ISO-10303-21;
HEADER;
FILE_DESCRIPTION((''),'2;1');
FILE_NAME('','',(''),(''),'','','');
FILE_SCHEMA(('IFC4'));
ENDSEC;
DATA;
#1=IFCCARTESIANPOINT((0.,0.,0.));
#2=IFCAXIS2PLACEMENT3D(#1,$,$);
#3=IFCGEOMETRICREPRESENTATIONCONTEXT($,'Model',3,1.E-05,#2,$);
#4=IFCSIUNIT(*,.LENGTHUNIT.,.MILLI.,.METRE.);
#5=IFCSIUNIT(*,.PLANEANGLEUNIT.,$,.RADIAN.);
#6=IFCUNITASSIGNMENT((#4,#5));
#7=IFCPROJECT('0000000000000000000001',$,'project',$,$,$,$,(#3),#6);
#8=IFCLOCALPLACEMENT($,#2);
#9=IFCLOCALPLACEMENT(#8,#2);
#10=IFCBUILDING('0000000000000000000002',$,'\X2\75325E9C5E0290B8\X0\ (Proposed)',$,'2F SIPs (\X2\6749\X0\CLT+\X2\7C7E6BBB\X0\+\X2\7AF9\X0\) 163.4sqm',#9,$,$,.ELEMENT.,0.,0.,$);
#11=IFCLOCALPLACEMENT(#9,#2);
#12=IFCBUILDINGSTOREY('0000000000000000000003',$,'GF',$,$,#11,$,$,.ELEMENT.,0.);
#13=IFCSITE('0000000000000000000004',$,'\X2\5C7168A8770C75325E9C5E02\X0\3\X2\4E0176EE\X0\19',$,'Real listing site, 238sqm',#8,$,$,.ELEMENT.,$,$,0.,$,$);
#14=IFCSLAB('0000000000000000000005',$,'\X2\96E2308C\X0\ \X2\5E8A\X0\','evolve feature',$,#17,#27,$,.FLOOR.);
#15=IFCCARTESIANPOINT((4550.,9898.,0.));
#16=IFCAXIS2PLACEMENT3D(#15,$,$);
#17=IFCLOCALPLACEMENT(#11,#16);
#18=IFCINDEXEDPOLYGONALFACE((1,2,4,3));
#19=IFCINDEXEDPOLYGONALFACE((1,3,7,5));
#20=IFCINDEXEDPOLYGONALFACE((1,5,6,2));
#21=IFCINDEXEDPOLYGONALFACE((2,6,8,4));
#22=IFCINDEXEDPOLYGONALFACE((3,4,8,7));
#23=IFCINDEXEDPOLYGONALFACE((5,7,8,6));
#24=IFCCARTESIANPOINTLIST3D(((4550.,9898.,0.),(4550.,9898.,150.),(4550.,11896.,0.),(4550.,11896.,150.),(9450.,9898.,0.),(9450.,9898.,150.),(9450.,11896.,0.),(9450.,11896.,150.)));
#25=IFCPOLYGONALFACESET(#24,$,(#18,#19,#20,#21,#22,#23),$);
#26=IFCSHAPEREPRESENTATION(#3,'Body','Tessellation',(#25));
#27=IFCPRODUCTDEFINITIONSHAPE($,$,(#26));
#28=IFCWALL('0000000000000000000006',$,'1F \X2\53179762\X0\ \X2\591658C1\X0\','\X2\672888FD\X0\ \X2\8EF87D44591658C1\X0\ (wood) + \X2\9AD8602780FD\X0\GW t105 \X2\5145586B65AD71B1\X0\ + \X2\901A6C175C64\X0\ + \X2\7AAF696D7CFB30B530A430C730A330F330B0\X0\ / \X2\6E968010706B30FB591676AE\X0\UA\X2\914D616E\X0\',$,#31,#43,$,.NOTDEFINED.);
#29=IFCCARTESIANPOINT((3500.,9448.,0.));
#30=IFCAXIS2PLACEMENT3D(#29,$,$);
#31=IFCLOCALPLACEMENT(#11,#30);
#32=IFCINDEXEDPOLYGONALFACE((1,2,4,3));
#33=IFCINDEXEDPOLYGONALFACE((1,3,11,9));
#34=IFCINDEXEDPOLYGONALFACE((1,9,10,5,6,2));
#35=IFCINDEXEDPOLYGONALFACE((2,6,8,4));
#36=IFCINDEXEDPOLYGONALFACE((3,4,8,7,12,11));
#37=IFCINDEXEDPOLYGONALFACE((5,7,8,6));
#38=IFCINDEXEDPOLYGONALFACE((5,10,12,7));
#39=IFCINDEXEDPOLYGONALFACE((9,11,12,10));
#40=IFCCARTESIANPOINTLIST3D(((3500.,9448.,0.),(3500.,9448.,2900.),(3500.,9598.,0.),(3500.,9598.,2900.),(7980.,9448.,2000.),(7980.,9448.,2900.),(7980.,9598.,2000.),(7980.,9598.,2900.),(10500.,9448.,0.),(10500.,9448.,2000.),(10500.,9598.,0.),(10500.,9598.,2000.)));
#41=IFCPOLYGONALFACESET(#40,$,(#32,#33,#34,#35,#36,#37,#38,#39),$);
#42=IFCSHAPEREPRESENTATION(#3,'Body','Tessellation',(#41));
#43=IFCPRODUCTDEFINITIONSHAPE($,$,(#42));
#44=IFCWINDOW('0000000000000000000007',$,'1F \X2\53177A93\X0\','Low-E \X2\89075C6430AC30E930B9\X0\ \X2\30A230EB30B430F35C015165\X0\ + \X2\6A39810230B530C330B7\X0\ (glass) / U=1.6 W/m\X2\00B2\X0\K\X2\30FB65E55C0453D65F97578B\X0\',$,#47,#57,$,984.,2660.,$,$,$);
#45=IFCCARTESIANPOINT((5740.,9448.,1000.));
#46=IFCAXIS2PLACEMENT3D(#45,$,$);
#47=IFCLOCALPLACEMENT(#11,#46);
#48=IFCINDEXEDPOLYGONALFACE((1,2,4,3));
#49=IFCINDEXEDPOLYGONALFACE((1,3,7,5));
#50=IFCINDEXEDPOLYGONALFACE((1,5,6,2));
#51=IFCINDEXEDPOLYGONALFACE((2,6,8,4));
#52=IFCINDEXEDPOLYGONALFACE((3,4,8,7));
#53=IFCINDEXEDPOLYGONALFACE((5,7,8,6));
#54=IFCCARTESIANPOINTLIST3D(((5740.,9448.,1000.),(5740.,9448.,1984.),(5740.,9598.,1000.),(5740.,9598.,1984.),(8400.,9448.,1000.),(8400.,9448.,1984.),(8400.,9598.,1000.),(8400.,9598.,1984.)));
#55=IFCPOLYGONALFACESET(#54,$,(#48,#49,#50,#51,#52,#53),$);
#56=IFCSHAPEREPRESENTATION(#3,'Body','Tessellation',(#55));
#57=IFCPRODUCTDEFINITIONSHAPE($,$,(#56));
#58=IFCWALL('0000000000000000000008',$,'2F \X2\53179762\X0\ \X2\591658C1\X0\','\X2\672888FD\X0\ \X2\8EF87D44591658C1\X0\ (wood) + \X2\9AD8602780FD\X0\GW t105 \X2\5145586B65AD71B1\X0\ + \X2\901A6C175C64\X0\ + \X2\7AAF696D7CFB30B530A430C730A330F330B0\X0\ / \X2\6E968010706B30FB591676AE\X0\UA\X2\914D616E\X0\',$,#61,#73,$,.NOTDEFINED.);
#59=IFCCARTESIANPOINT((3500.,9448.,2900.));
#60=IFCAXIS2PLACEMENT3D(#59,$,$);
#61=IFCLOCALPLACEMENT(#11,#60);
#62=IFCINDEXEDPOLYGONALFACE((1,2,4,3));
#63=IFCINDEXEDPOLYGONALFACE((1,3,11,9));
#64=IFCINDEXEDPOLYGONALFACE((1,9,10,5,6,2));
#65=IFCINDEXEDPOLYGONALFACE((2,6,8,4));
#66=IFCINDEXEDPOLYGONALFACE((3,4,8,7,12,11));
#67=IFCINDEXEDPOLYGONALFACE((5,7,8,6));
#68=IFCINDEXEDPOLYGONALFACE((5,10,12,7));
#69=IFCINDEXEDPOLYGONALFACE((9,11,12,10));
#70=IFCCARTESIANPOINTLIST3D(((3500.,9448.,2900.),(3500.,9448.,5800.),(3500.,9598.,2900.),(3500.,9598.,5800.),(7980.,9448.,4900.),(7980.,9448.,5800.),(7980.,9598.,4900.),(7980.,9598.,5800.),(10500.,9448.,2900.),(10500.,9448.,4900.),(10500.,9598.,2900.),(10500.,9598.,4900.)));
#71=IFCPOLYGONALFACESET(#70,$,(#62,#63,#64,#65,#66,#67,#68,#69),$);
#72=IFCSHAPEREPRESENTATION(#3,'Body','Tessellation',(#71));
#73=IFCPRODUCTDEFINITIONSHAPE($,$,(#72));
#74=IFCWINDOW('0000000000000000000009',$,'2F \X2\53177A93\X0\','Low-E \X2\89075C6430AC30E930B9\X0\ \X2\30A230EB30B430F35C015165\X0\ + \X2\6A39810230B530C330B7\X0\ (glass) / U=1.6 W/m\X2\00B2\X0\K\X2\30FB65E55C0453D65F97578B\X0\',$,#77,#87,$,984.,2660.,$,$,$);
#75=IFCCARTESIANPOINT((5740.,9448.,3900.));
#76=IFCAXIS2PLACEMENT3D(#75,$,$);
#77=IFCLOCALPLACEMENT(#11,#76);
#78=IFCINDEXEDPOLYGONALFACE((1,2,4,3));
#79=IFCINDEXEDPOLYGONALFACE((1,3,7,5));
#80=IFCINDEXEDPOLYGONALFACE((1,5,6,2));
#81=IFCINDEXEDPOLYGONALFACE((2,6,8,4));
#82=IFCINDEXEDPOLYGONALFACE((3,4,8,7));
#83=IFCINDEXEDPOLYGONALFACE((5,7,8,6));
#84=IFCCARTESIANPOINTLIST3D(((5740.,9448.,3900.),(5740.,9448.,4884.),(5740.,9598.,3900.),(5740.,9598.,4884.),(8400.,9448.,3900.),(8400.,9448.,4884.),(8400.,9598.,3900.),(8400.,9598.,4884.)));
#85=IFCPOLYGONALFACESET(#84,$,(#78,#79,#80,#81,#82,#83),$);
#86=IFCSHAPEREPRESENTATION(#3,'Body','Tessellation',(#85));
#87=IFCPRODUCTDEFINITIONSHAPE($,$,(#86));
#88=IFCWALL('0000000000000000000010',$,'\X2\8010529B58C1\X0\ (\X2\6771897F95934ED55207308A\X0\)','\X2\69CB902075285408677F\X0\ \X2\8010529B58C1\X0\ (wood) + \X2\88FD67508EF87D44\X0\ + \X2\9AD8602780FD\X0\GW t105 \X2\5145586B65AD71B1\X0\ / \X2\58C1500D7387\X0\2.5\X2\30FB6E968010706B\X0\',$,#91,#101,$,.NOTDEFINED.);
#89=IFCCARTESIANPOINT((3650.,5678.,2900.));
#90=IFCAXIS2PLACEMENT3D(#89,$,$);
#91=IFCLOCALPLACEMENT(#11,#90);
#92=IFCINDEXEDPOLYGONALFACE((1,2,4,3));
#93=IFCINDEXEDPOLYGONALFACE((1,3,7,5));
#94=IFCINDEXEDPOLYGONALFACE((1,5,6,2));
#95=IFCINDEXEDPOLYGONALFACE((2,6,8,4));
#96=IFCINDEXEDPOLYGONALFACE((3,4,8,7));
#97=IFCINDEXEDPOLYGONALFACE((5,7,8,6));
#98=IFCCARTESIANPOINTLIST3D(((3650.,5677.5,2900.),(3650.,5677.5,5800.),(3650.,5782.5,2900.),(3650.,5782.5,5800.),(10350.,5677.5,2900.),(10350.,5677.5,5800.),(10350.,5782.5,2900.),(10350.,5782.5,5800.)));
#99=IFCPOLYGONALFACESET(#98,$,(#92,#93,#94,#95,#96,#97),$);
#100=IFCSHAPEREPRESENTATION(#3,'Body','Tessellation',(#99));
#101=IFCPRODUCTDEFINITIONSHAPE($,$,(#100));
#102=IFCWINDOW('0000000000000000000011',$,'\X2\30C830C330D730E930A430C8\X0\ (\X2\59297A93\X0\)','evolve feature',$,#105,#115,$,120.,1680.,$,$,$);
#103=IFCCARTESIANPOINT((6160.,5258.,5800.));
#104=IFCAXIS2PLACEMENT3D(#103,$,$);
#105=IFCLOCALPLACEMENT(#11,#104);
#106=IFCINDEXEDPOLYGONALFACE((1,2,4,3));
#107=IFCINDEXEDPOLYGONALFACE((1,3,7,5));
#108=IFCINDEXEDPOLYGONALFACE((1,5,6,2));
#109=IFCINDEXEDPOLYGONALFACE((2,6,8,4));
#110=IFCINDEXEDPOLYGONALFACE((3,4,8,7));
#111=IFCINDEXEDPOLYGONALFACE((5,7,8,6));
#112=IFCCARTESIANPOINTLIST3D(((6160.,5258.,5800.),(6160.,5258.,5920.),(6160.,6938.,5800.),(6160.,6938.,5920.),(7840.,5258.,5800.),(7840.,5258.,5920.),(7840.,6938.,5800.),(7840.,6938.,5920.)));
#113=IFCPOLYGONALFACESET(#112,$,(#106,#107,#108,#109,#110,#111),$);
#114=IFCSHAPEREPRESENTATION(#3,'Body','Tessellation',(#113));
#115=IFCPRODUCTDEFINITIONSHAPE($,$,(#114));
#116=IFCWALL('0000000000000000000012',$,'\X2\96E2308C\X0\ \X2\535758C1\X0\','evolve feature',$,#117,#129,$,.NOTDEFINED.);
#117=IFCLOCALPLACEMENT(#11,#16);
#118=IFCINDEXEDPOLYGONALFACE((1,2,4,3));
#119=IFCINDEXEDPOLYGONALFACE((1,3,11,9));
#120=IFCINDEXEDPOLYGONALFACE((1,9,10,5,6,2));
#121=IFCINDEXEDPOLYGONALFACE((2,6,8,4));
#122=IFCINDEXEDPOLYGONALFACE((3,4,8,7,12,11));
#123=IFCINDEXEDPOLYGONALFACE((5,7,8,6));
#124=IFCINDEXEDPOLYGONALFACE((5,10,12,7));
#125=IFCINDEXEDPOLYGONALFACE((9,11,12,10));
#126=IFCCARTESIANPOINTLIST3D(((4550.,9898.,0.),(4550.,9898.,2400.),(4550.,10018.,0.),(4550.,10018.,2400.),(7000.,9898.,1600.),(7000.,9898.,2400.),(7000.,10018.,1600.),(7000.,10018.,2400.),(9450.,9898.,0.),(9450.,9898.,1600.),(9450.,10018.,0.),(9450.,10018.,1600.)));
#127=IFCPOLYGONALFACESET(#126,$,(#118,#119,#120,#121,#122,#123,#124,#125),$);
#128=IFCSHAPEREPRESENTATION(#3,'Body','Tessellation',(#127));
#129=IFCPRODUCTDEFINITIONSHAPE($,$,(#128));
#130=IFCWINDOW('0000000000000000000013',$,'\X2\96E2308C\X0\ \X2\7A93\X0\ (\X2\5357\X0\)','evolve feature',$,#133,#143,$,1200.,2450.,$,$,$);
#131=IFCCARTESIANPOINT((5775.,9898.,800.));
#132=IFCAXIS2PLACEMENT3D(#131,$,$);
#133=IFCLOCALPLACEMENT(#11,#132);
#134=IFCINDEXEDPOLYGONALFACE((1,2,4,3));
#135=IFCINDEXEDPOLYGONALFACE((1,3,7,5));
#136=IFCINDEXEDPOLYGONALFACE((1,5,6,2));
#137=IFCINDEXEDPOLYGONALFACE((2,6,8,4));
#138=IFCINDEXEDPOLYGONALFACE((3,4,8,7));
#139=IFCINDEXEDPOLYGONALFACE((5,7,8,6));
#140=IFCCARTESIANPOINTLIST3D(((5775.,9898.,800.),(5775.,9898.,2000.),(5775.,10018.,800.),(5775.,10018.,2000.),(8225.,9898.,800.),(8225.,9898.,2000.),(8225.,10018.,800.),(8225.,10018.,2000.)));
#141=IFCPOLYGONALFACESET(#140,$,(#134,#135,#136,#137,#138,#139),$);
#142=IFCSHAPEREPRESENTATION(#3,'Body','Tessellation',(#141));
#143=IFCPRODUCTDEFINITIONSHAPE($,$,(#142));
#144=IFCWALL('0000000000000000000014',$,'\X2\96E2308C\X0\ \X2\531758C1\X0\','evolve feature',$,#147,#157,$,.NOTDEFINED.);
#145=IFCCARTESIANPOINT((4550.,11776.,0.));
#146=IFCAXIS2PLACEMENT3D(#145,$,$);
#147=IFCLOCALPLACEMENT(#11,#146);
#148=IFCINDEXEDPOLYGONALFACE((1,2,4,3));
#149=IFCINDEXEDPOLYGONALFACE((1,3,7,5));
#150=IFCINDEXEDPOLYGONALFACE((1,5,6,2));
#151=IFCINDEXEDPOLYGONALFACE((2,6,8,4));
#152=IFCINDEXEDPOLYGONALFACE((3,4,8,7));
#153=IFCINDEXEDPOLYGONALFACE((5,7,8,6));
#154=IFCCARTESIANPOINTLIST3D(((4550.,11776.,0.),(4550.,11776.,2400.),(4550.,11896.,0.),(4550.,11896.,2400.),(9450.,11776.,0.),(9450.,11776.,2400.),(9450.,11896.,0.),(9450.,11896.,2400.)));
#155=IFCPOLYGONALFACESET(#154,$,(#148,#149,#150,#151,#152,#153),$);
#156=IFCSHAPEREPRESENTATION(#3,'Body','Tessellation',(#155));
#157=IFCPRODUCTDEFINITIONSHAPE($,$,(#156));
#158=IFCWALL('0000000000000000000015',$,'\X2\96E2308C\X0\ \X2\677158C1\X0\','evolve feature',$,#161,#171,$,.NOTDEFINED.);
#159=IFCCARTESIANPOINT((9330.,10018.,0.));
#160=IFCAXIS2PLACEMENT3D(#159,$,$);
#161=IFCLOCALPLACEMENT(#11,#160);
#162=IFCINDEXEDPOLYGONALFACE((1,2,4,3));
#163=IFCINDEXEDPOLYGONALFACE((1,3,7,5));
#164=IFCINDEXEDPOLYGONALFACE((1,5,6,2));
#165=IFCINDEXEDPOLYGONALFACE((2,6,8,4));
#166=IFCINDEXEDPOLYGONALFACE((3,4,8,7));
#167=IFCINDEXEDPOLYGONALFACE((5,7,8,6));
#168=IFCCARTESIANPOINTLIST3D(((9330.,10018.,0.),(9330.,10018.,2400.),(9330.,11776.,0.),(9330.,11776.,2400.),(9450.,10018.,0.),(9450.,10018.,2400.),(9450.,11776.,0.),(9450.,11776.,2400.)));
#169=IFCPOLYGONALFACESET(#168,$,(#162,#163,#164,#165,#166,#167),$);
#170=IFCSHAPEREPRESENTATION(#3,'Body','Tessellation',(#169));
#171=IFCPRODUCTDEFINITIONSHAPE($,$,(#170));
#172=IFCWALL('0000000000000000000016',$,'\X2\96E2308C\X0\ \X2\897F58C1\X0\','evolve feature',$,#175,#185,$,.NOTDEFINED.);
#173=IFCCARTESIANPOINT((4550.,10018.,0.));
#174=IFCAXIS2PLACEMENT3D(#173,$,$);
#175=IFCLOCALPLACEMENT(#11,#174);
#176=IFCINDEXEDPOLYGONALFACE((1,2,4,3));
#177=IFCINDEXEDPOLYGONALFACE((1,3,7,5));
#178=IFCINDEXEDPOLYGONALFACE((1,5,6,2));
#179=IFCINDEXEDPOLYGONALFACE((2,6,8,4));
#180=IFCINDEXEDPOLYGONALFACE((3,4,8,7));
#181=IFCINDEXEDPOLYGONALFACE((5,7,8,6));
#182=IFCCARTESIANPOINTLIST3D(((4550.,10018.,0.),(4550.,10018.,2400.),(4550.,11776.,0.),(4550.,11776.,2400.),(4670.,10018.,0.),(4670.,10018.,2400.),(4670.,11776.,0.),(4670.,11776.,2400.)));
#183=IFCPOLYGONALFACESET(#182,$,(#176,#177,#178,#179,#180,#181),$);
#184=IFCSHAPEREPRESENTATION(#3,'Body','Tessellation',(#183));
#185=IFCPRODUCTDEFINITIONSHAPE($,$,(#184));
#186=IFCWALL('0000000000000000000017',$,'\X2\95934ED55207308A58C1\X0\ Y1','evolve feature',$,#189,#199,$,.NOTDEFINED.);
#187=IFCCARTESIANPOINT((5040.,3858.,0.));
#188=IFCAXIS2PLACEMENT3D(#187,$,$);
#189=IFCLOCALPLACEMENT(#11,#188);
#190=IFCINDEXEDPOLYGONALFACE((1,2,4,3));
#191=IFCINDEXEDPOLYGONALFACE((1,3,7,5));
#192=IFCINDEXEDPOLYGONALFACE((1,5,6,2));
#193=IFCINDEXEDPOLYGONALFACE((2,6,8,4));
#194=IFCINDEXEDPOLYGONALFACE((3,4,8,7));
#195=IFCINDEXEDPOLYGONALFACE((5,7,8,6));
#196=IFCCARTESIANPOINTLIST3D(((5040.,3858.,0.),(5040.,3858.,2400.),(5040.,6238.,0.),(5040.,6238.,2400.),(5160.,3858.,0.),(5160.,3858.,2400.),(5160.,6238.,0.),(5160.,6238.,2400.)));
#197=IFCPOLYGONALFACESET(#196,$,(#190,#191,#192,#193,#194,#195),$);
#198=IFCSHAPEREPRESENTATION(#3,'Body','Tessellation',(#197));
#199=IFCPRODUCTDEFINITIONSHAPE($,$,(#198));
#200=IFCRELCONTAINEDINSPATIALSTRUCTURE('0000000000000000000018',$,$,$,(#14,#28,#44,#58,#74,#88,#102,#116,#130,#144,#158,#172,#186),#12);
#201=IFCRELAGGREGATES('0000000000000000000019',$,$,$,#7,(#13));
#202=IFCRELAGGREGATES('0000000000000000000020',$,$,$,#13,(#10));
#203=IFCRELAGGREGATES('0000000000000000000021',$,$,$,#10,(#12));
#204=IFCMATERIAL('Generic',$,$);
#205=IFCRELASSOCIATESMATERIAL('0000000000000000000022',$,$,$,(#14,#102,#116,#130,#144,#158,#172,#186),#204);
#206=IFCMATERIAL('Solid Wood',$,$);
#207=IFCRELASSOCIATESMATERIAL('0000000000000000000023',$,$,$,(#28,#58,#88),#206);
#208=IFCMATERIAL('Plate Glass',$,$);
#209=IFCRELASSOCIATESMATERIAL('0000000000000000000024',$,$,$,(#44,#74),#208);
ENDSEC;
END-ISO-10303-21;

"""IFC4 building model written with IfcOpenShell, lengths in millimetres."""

from ifc_helpers import new_model, si_unit, frame, frame_2d, origin, place, context, project, spatial, rectangle, extrude, material, element, fill, save


model = new_model("IFC4")

# Units and contexts
model_context = context("Model", 3, precision=1e-05, world=origin())
ifc_project = project(units=[si_unit("LENGTHUNIT", "METRE", prefix="MILLI"), si_unit("PLANEANGLEUNIT", "RADIAN")], contexts=[model_context])

# Site, building, storey
site_placement = place(None, origin())
site = spatial("IfcSite", under=ifc_project, at=site_placement, Name="山梨県甲府市3丁目19", ObjectType="Real listing site, 238sqm", CompositionType="ELEMENT", RefElevation=0.0)
building_placement = place(site_placement, origin())
building = spatial("IfcBuilding", under=site, at=building_placement, Name="甲府市邸 (Proposed)", ObjectType="2F SIPs (杉CLT+籾殻+竹) 163.4sqm", CompositionType="ELEMENT", ElevationOfRefHeight=0.0, ElevationOfTerrain=0.0)
storey_placement = place(building_placement, origin())
storey = spatial("IfcBuildingStorey", under=building, at=storey_placement, Name="GF", CompositionType="ELEMENT", Elevation=0.0)

# Slab
ifc_material_1 = material(Name="Generic")
slab_placement = place(storey_placement, frame((4550.0, 9898.0, 0.0)))
element("IfcSlab", 1, at=slab_placement, inside=storey, material=ifc_material_1, Name="離れ 床", Description="evolve feature", PredefinedType="FLOOR", context=model_context, shape_type="SweptSolid", body=[
    extrude(rectangle(XDim=4900.0, YDim=1998.0, at=frame_2d((2450.0, 999.0))), frame((4550.0, 9898.0, 0.0)), (0.0, 0.0, 1.0), 150.0),
])

# Wall, opening, window
ifc_material_2 = material(Name="Solid Wood")
wall_1_placement = place(storey_placement, frame((3500.0, 9448.0, 0.0)))
wall_1 = element("IfcWall", 2, at=wall_1_placement, inside=storey, material=ifc_material_2, Name="1F 北面 外壁", Description="木製 軸組外壁 (wood) + 高性能GW t105 充填断熱 + 通気層 + 窯業系サイディング / 準耐火・外皮UA配慮", PredefinedType="NOTDEFINED", context=model_context, shape_type="SweptSolid", body=[
    extrude(rectangle(XDim=7000.0, YDim=150.0, at=frame_2d((3500.0, 75.0))), frame((3500.0, 9448.0, 0.0)), (0.0, 0.0, 1.0), 2900.0),
])
opening_1_placement = place(storey_placement, frame((5740.0, 9448.0, 1000.0)))
opening_1 = element("IfcOpeningElement", 3, at=opening_1_placement, cuts=wall_1, PredefinedType="NOTDEFINED", context=model_context, shape_type="SweptSolid", body=[
    extrude(rectangle(XDim=2660.0, YDim=150.0, at=frame_2d((1330.0, 75.0))), frame((5740.0, 9448.0, 1000.0)), (0.0, 0.0, 1.0), 984.0),
])
ifc_material_3 = material(Name="Plate Glass")
window_1_placement = place(storey_placement, frame((5740.0, 9448.0, 1000.0)))
window_1 = element("IfcWindow", 4, at=window_1_placement, inside=storey, material=ifc_material_3, Name="1F 北窓", Description="Low-E 複層ガラス アルゴン封入 + 樹脂サッシ (glass) / U=1.6 W/m²K・日射取得型", OverallHeight=984.0, OverallWidth=2660.0, context=model_context, shape_type="SweptSolid", body=[
    extrude(rectangle(XDim=2660.0, YDim=150.0, at=frame_2d((1330.0, 75.0))), frame((5740.0, 9448.0, 1000.0)), (0.0, 0.0, 1.0), 984.0),
])
fill(opening_1, window_1)

# Wall, opening, window
wall_2_placement = place(storey_placement, frame((3500.0, 9448.0, 2900.0)))
wall_2 = element("IfcWall", 5, at=wall_2_placement, inside=storey, material=ifc_material_2, Name="2F 北面 外壁", Description="木製 軸組外壁 (wood) + 高性能GW t105 充填断熱 + 通気層 + 窯業系サイディング / 準耐火・外皮UA配慮", PredefinedType="NOTDEFINED", context=model_context, shape_type="SweptSolid", body=[
    extrude(rectangle(XDim=7000.0, YDim=150.0, at=frame_2d((3500.0, 75.0))), frame((3500.0, 9448.0, 2900.0)), (0.0, 0.0, 1.0), 2900.0),
])
opening_2_placement = place(storey_placement, frame((5740.0, 9448.0, 3900.0)))
opening_2 = element("IfcOpeningElement", 6, at=opening_2_placement, cuts=wall_2, PredefinedType="NOTDEFINED", context=model_context, shape_type="SweptSolid", body=[
    extrude(rectangle(XDim=2660.0, YDim=150.0, at=frame_2d((1330.0, 75.0))), frame((5740.0, 9448.0, 3900.0)), (0.0, 0.0, 1.0), 984.0),
])
window_2_placement = place(storey_placement, frame((5740.0, 9448.0, 3900.0)))
window_2 = element("IfcWindow", 7, at=window_2_placement, inside=storey, material=ifc_material_3, Name="2F 北窓", Description="Low-E 複層ガラス アルゴン封入 + 樹脂サッシ (glass) / U=1.6 W/m²K・日射取得型", OverallHeight=984.0, OverallWidth=2660.0, context=model_context, shape_type="SweptSolid", body=[
    extrude(rectangle(XDim=2660.0, YDim=150.0, at=frame_2d((1330.0, 75.0))), frame((5740.0, 9448.0, 3900.0)), (0.0, 0.0, 1.0), 984.0),
])
fill(opening_2, window_2)

# Wall
wall_3_placement = place(storey_placement, frame((3650.0, 5678.0, 2900.0)))
element("IfcWall", 8, at=wall_3_placement, inside=storey, material=ifc_material_2, Name="耐力壁 (東西間仕切り)", Description="構造用合板 耐力壁 (wood) + 製材軸組 + 高性能GW t105 充填断熱 / 壁倍率2.5・準耐火", PredefinedType="NOTDEFINED", context=model_context, shape_type="SweptSolid", body=[
    extrude(rectangle(XDim=6700.0, YDim=105.0, at=frame_2d((3350.0, 52.0))), frame((3650.0, 5678.0, 2900.0)), (0.0, 0.0, 1.0), 2900.0),
])

# Window
window_3_placement = place(storey_placement, frame((6160.0, 5258.0, 5800.0)))
element("IfcWindow", 9, at=window_3_placement, inside=storey, material=ifc_material_1, Name="トップライト (天窓)", Description="evolve feature", OverallHeight=120.0, OverallWidth=1680.0, context=model_context, shape_type="SweptSolid", body=[
    extrude(rectangle(XDim=1680.0, YDim=1680.0, at=frame_2d((840.0, 840.0))), frame((6160.0, 5258.0, 5800.0)), (0.0, 0.0, 1.0), 120.0),
])

# Wall, opening, window
wall_4_placement = place(storey_placement, frame((4550.0, 9898.0, 0.0)))
wall_4 = element("IfcWall", 10, at=wall_4_placement, inside=storey, material=ifc_material_1, Name="離れ 南壁", Description="evolve feature", PredefinedType="NOTDEFINED", context=model_context, shape_type="SweptSolid", body=[
    extrude(rectangle(XDim=4900.0, YDim=120.0, at=frame_2d((2450.0, 60.0))), frame((4550.0, 9898.0, 0.0)), (0.0, 0.0, 1.0), 2400.0),
])
opening_3_placement = place(storey_placement, frame((5775.0, 9898.0, 800.0)))
opening_3 = element("IfcOpeningElement", 11, at=opening_3_placement, cuts=wall_4, PredefinedType="NOTDEFINED", context=model_context, shape_type="SweptSolid", body=[
    extrude(rectangle(XDim=2450.0, YDim=120.0, at=frame_2d((1225.0, 60.0))), frame((5775.0, 9898.0, 800.0)), (0.0, 0.0, 1.0), 1200.0),
])
window_4_placement = place(storey_placement, frame((5775.0, 9898.0, 800.0)))
window_4 = element("IfcWindow", 12, at=window_4_placement, inside=storey, material=ifc_material_1, Name="離れ 窓 (南)", Description="evolve feature", OverallHeight=1200.0, OverallWidth=2450.0, context=model_context, shape_type="SweptSolid", body=[
    extrude(rectangle(XDim=2450.0, YDim=120.0, at=frame_2d((1225.0, 60.0))), frame((5775.0, 9898.0, 800.0)), (0.0, 0.0, 1.0), 1200.0),
])
fill(opening_3, window_4)

# Walls
wall_5_placement = place(storey_placement, frame((4550.0, 11776.0, 0.0)))
element("IfcWall", 13, at=wall_5_placement, inside=storey, material=ifc_material_1, Name="離れ 北壁", Description="evolve feature", PredefinedType="NOTDEFINED", context=model_context, shape_type="SweptSolid", body=[
    extrude(rectangle(XDim=4900.0, YDim=120.0, at=frame_2d((2450.0, 60.0))), frame((4550.0, 11776.0, 0.0)), (0.0, 0.0, 1.0), 2400.0),
])
wall_6_placement = place(storey_placement, frame((9330.0, 10018.0, 0.0)))
element("IfcWall", 14, at=wall_6_placement, inside=storey, material=ifc_material_1, Name="離れ 東壁", Description="evolve feature", PredefinedType="NOTDEFINED", context=model_context, shape_type="SweptSolid", body=[
    extrude(rectangle(XDim=120.0, YDim=1758.0, at=frame_2d((60.0, 879.0))), frame((9330.0, 10018.0, 0.0)), (0.0, 0.0, 1.0), 2400.0),
])
wall_7_placement = place(storey_placement, frame((4550.0, 10018.0, 0.0)))
element("IfcWall", 15, at=wall_7_placement, inside=storey, material=ifc_material_1, Name="離れ 西壁", Description="evolve feature", PredefinedType="NOTDEFINED", context=model_context, shape_type="SweptSolid", body=[
    extrude(rectangle(XDim=120.0, YDim=1758.0, at=frame_2d((60.0, 879.0))), frame((4550.0, 10018.0, 0.0)), (0.0, 0.0, 1.0), 2400.0),
])
wall_8_placement = place(storey_placement, frame((5040.0, 3858.0, 0.0)))
element("IfcWall", 16, at=wall_8_placement, inside=storey, material=ifc_material_1, Name="間仕切り壁 Y1", Description="evolve feature", PredefinedType="NOTDEFINED", context=model_context, shape_type="SweptSolid", body=[
    extrude(rectangle(XDim=120.0, YDim=2380.0, at=frame_2d((60.0, 1190.0))), frame((5040.0, 3858.0, 0.0)), (0.0, 0.0, 1.0), 2400.0),
])

save(model, "model.ifc")
